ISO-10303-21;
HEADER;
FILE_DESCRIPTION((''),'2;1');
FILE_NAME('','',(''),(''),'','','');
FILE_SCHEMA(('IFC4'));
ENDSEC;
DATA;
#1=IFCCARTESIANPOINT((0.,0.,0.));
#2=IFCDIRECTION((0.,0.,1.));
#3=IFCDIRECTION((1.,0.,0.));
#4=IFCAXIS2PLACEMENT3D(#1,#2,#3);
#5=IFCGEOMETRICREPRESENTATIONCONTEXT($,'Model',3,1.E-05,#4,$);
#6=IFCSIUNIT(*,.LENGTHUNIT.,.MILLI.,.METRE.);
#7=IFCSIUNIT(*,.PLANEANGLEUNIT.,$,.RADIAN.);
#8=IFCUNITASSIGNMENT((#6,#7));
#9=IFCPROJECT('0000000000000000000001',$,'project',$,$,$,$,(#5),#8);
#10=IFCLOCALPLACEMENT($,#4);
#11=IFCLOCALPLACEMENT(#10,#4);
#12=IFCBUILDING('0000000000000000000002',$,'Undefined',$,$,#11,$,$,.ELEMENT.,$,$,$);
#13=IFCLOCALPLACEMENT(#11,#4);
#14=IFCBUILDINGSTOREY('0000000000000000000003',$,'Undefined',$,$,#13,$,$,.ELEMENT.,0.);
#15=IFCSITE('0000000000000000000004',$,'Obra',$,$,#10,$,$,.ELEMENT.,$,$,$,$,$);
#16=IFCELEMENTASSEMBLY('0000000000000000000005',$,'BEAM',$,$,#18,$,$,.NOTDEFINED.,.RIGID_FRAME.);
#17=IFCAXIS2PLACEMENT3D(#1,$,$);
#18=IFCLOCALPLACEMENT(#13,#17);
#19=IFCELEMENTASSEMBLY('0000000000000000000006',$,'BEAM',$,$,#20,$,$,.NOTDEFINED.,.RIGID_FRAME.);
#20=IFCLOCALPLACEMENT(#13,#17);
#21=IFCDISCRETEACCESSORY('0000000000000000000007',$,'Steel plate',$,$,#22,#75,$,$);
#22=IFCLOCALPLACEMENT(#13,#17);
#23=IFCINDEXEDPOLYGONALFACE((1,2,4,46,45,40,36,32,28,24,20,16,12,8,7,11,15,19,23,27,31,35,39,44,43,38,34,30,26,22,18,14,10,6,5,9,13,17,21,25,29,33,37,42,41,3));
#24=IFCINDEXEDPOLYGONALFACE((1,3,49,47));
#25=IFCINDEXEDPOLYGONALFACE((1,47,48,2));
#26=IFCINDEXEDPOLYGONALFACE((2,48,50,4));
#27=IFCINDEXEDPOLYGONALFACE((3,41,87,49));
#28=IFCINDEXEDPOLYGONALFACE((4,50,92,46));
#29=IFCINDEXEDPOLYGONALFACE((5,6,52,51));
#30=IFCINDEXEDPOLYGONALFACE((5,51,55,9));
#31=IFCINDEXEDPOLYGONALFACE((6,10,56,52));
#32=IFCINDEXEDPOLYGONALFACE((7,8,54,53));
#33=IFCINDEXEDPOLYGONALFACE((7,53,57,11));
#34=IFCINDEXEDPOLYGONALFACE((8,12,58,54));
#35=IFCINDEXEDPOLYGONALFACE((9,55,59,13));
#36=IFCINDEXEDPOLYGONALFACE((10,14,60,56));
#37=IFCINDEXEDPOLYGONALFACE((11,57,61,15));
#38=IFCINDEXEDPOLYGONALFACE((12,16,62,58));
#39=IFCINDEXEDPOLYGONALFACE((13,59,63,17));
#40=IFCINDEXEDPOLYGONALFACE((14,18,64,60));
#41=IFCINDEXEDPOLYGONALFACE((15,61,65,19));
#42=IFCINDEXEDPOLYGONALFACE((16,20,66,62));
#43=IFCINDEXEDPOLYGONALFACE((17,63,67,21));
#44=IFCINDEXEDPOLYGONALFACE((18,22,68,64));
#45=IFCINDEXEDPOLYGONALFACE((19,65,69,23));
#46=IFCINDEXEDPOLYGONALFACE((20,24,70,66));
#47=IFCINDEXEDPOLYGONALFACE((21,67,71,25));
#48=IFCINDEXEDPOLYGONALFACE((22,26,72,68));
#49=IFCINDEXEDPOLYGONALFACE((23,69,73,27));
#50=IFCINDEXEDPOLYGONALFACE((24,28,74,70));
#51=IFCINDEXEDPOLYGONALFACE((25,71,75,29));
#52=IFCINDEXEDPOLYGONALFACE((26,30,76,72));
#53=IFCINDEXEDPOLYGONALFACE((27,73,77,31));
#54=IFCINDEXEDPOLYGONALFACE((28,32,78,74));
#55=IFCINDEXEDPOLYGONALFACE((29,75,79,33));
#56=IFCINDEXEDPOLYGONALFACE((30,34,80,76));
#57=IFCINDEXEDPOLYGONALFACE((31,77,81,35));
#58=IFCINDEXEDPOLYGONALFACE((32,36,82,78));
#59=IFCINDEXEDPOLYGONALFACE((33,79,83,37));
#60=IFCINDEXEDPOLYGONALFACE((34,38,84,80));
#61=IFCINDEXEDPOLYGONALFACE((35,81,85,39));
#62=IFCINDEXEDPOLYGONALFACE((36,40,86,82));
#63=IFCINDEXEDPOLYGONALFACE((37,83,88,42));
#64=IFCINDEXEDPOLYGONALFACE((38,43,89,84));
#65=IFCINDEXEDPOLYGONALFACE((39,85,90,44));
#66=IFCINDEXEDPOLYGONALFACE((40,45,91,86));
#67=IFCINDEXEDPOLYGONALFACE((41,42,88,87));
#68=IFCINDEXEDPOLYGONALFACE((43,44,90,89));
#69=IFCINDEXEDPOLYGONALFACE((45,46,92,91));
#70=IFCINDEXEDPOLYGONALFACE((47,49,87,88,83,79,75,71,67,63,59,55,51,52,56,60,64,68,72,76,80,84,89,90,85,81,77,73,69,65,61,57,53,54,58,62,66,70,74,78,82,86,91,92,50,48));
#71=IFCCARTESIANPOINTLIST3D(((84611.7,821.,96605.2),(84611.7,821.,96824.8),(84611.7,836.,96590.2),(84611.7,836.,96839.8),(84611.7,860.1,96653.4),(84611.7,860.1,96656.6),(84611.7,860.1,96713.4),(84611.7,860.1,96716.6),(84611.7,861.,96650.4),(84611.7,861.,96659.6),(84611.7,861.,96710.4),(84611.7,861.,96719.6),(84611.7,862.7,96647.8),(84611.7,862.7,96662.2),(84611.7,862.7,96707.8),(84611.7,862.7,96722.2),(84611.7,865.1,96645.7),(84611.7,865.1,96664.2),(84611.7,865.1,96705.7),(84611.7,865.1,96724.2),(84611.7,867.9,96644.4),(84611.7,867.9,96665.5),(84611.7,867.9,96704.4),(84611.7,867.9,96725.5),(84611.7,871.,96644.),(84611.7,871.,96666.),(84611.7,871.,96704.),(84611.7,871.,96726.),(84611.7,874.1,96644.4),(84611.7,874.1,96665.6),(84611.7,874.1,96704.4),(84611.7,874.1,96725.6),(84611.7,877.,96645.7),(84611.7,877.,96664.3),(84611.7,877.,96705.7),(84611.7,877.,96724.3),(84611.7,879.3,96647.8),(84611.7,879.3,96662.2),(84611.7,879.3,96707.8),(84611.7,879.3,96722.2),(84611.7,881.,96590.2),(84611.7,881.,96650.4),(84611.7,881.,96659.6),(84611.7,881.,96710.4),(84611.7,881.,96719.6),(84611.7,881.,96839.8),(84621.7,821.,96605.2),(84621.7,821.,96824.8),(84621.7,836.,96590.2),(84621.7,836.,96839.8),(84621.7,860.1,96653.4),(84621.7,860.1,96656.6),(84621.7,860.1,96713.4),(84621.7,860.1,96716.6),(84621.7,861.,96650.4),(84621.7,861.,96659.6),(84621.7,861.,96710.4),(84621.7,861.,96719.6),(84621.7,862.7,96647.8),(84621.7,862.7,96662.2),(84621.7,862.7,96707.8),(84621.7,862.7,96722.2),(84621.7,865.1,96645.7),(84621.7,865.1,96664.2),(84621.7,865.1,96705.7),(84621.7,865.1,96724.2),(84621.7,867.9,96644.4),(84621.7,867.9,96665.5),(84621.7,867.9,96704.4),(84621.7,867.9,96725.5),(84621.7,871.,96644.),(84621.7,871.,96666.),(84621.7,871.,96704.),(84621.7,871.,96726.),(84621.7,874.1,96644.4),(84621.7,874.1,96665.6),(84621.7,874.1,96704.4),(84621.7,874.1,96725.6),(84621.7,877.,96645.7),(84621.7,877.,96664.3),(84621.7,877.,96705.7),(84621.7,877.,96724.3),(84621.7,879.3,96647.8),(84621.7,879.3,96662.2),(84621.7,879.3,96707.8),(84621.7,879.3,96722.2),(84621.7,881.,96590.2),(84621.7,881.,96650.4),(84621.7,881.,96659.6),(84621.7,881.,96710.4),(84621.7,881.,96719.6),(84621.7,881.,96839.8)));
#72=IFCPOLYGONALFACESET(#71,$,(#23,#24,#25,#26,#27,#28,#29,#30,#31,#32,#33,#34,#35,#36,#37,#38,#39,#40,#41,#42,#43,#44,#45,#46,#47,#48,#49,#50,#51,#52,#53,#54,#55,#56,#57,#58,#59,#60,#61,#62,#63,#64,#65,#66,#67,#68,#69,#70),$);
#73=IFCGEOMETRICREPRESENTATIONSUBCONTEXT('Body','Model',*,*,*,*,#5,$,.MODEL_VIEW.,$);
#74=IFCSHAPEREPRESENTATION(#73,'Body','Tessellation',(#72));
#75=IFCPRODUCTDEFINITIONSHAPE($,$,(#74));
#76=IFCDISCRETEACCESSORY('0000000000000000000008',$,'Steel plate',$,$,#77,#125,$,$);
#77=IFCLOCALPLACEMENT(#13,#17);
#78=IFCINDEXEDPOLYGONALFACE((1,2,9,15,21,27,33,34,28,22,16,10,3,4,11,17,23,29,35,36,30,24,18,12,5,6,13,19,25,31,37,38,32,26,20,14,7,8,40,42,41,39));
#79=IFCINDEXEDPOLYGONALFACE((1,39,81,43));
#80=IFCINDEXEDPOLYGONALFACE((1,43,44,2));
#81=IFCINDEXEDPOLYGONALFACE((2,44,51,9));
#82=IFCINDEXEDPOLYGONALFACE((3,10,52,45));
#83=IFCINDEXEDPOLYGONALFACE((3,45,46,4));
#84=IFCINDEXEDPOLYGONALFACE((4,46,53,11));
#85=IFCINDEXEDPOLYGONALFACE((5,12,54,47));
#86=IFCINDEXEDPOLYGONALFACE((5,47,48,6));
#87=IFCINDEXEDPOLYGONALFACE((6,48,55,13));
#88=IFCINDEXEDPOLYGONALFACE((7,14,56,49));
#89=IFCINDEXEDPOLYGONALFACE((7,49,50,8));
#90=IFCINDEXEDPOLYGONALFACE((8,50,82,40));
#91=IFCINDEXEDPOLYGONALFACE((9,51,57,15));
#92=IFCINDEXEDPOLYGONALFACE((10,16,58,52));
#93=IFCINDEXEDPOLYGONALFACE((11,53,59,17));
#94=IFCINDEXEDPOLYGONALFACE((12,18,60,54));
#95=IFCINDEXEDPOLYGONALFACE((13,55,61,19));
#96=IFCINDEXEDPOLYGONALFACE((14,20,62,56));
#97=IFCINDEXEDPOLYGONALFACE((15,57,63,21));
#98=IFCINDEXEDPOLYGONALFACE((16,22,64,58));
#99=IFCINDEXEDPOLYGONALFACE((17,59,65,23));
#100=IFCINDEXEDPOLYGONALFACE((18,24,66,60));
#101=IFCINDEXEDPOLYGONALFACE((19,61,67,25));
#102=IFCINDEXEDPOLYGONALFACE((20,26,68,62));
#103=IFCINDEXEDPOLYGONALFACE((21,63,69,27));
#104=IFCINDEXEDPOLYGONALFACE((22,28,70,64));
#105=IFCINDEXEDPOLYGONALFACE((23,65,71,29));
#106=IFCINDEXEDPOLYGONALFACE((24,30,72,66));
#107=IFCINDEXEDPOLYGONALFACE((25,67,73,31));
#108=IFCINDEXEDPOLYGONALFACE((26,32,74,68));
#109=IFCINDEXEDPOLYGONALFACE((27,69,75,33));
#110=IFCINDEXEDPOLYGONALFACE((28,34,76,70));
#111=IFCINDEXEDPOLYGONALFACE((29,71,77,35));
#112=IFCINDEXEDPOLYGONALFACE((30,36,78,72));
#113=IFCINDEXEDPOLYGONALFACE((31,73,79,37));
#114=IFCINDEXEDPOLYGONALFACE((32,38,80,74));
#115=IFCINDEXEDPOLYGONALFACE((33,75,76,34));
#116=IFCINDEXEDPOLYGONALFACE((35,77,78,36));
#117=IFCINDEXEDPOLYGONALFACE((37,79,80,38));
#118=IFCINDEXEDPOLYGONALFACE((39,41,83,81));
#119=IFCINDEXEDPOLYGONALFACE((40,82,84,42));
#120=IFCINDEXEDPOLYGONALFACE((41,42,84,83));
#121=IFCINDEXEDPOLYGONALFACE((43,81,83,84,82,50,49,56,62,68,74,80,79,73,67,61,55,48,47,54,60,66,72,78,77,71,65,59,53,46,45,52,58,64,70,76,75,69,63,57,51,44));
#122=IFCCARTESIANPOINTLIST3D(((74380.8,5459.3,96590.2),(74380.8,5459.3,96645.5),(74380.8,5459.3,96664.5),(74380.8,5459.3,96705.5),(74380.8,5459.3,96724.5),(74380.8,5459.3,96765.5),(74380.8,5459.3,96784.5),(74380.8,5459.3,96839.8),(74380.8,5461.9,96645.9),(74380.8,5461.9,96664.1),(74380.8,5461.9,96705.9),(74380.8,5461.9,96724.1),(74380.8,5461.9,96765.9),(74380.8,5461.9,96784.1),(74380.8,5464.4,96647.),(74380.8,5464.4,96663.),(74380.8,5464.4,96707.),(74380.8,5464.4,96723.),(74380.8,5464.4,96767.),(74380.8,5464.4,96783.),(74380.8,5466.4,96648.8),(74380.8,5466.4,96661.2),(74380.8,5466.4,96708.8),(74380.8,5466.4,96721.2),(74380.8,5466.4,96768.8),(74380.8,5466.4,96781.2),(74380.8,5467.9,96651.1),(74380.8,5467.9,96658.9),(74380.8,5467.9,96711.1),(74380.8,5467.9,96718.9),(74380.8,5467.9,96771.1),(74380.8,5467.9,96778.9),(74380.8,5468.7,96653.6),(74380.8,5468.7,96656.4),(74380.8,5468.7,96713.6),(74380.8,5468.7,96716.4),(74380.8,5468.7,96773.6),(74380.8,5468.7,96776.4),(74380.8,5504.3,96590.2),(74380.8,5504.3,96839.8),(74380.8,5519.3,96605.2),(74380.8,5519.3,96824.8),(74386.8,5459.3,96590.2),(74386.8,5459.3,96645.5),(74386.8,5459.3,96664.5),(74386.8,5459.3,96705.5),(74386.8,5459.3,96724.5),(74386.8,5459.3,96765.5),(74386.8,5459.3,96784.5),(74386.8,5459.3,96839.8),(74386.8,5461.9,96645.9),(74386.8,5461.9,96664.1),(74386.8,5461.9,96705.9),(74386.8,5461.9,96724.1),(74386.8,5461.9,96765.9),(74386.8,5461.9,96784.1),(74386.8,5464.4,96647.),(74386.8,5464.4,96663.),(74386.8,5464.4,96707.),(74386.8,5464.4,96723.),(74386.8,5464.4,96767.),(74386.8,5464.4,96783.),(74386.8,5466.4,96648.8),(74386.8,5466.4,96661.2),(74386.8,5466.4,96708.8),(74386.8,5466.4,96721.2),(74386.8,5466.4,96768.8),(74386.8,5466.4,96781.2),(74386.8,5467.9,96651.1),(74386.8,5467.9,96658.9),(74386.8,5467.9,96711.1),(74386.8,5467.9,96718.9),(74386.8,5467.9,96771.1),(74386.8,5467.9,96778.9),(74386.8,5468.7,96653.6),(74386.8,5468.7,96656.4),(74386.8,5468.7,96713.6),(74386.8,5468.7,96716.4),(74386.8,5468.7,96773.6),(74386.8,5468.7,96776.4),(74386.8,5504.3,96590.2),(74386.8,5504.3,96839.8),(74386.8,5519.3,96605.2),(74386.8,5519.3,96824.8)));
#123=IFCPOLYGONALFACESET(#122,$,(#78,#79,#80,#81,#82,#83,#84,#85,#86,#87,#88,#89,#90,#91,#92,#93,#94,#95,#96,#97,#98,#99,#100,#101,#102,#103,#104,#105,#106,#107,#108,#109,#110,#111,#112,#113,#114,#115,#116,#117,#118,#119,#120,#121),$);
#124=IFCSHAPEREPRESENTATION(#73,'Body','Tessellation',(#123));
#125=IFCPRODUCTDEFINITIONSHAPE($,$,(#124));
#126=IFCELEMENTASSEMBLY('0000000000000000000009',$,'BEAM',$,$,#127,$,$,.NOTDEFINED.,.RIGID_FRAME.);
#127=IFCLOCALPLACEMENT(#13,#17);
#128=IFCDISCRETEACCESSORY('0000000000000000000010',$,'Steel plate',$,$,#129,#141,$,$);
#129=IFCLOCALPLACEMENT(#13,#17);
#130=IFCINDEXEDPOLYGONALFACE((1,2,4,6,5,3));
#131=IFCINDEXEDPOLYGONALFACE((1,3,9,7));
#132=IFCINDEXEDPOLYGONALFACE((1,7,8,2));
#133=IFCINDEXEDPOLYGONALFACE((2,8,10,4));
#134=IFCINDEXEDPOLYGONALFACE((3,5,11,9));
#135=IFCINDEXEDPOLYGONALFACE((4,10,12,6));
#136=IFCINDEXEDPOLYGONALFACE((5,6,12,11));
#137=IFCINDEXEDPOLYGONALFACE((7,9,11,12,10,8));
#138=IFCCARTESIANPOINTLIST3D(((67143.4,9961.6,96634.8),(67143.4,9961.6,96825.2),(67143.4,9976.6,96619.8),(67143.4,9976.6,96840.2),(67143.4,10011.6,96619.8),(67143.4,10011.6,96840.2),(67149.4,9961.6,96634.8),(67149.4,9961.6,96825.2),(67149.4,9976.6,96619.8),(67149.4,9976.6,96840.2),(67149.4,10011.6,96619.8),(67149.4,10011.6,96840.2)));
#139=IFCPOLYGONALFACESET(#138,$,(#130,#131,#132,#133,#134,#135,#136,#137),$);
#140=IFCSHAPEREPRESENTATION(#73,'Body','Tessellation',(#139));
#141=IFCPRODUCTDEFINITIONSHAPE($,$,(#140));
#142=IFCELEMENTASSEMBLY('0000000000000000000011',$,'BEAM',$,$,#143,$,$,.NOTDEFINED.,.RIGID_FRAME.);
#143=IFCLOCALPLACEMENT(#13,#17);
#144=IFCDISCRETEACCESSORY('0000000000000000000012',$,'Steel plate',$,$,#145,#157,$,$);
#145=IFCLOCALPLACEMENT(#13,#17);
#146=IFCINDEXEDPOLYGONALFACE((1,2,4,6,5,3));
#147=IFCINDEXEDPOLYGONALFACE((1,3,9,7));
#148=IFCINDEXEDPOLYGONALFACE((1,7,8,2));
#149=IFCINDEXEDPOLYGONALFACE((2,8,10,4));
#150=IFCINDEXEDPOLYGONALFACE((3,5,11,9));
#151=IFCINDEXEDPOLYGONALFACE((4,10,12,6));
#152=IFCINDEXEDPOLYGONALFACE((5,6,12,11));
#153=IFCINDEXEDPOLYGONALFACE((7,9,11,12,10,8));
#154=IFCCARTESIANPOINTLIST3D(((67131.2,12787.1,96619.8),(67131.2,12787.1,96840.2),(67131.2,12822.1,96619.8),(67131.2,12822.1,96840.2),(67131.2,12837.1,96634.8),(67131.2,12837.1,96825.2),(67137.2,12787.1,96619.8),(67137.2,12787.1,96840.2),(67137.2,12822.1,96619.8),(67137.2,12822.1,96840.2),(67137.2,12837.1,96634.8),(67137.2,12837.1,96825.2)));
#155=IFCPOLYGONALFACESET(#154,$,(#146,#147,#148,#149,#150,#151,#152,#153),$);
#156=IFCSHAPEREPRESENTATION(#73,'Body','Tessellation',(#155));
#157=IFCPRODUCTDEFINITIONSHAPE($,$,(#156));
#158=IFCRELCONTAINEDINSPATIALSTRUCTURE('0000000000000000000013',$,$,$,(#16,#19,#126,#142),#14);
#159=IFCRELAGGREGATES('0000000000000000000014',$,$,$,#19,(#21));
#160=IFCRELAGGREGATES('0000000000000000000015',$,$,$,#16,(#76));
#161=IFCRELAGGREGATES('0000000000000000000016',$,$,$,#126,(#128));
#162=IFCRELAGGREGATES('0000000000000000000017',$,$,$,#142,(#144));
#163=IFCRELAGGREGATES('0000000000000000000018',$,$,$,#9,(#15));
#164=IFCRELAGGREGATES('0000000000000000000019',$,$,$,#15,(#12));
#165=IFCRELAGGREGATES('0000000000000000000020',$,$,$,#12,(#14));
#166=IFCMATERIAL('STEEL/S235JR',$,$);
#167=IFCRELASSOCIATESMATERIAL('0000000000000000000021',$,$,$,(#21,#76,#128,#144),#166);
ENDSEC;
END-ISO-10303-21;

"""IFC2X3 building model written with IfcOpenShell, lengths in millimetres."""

from ifc_helpers import new_model, si_unit, frame, origin_with_axes, origin_2d_with_axis, place, context, subcontext, project, spatial, polyline, circle, outline, extrude, source, transform, mapped, material, element, aggregate, save


model = new_model("IFC2X3")

# Units and contexts
model_context = context("Model", 3, precision=1e-05, world=origin_with_axes())
body_context = subcontext(model_context, "Body", "Model", "MODEL_VIEW")
ifc_project = project(units=[si_unit("LENGTHUNIT", "METRE", prefix="MILLI"), si_unit("PLANEANGLEUNIT", "RADIAN")], contexts=[model_context])

# Site, building, storey
site_placement = place(None, origin_with_axes())
site = spatial("IfcSite", under=ifc_project, at=site_placement, Name="Obra", CompositionType="ELEMENT")
building_placement = place(site_placement, origin_with_axes())
building = spatial("IfcBuilding", under=site, at=building_placement, Name="Undefined", CompositionType="ELEMENT")
storey_placement = place(building_placement, origin_with_axes())
storey = spatial("IfcBuildingStorey", under=building, at=storey_placement, Name="Undefined", CompositionType="ELEMENT", Elevation=0.0)

# Shared definitions
ifc_material = material(Name="STEEL/S235JR")

# Element assembly
assembly_1_placement = place(storey_placement, origin_with_axes())
assembly_1 = element("IfcElementAssembly", 1, at=assembly_1_placement, inside=storey, Name="BEAM", AssemblyPlace="NOTDEFINED", PredefinedType="RIGID_FRAME")
shared_shape_1 = source(origin_with_axes(), body_context, "Body", "SweptSolid", [
    extrude(circle(Radius=9.5, at=origin_2d_with_axis()), frame((0.0, -9.4, 0.0), z_axis=(0.0, 1.0, 0.0), x_axis=(1.0, 0.0, 0.0)), (0.0, 0.0, 1.0), 6.2),
])

# Element assembly, discrete accessory, opening
assembly_2_placement = place(storey_placement, origin_with_axes())
assembly_2 = element("IfcElementAssembly", 2, at=assembly_2_placement, inside=storey, Name="BEAM", AssemblyPlace="NOTDEFINED", PredefinedType="RIGID_FRAME")
discrete_accessory_1_placement = place(assembly_2_placement, frame((84616.7, 881.0, 96590.2), z_axis=(-1.0, 0.0, 0.0), x_axis=(0.0, -1.0, 0.0)))
discrete_accessory_1 = element("IfcDiscreteAccessory", 3, at=discrete_accessory_1_placement, material=ifc_material, Name="Steel plate", context=body_context, shape_type="SweptSolid", body=[
    extrude(outline(polyline([(0.0, 0.0), (45.0, 0.0), (60.0, 15.0), (60.0, 234.6), (45.0, 249.6), (0.0, 249.6), (0.0, 0.0)])), frame((0.0, 0.0, -5.0), z_axis=(0.0, 0.0, 1.0), x_axis=(1.0, 0.0, 0.0)), (0.0, 0.0, 1.0), 10.0),
])
shared_shape_2 = source(origin_with_axes(), body_context, "Body", "SweptSolid", [
    extrude(circle(Radius=11.0, at=origin_2d_with_axis()), frame((0.0, -13.9, 0.0), z_axis=(0.0, 1.0, 0.0), x_axis=(1.0, 0.0, 0.0)), (0.0, 0.0, 1.0), 10.2),
])
opening_1_placement = place(assembly_2_placement, frame((84607.9, 831.0, 96850.0), z_axis=(0.0, 1.0, 0.0), x_axis=(0.0, 0.0, -1.0)))
element("IfcOpeningElement", 4, at=opening_1_placement, cuts=discrete_accessory_1, ObjectType="Opening", context=body_context, shape_type="MappedRepresentation", body=[
    mapped(shared_shape_2, transform((135.0, 0.0, 40.0))),
    mapped(shared_shape_2, transform((195.0, 0.0, 40.0))),
])
aggregate(assembly_2, [discrete_accessory_1])

# Discrete accessory, opening
discrete_accessory_2_placement = place(assembly_1_placement, frame((74383.8, 5459.3, 96590.2), z_axis=(1.0, 0.0, 0.0), x_axis=(0.0, 1.0, 0.0)))
discrete_accessory_2 = element("IfcDiscreteAccessory", 5, at=discrete_accessory_2_placement, material=ifc_material, Name="Steel plate", context=body_context, shape_type="SweptSolid", body=[
    extrude(outline(polyline([(0.0, 0.0), (45.0, 0.0), (60.0, 15.0), (60.0, 234.6), (45.0, 249.6), (0.0, 249.6), (0.0, 0.0)])), frame((0.0, 0.0, -3.0), z_axis=(0.0, 0.0, 1.0), x_axis=(1.0, 0.0, 0.0)), (0.0, 0.0, 1.0), 6.0),
])
opening_2_placement = place(assembly_1_placement, frame((74390.1, 5509.3, 96850.0), z_axis=(0.0, -1.0, 0.0), x_axis=(0.0, 0.0, -1.0)))
element("IfcOpeningElement", 6, at=opening_2_placement, cuts=discrete_accessory_2, ObjectType="Opening", context=body_context, shape_type="MappedRepresentation", body=[
    mapped(shared_shape_1, transform((75.0, 0.0, 50.0))),
    mapped(shared_shape_1, transform((135.0, 0.0, 50.0))),
    mapped(shared_shape_1, transform((195.0, 0.0, 50.0))),
])
aggregate(assembly_1, [discrete_accessory_2])

# Element assemblies, discrete accessories
assembly_3_placement = place(storey_placement, origin_with_axes())
assembly_3 = element("IfcElementAssembly", 7, at=assembly_3_placement, inside=storey, Name="BEAM", AssemblyPlace="NOTDEFINED", PredefinedType="RIGID_FRAME")
discrete_accessory_3_placement = place(assembly_3_placement, frame((67146.4, 10011.6, 96619.8), z_axis=(-1.0, 0.0, 0.0), x_axis=(0.0, -1.0, 0.0)))
discrete_accessory_3 = element("IfcDiscreteAccessory", 8, at=discrete_accessory_3_placement, material=ifc_material, Name="Steel plate", context=body_context, shape_type="SweptSolid", body=[
    extrude(outline(polyline([(0.0, 0.0), (35.0, 0.0), (50.0, 15.0), (50.0, 205.4), (35.0, 220.4), (0.0, 220.4), (0.0, 0.0)])), frame((0.0, 0.0, -3.0), z_axis=(0.0, 0.0, 1.0), x_axis=(1.0, 0.0, 0.0)), (0.0, 0.0, 1.0), 6.0),
])
aggregate(assembly_3, [discrete_accessory_3])
assembly_4_placement = place(storey_placement, origin_with_axes())
assembly_4 = element("IfcElementAssembly", 9, at=assembly_4_placement, inside=storey, Name="BEAM", AssemblyPlace="NOTDEFINED", PredefinedType="RIGID_FRAME")
discrete_accessory_4_placement = place(assembly_4_placement, frame((67134.2, 12787.1, 96619.8), z_axis=(1.0, 0.0, 0.0), x_axis=(0.0, 1.0, 0.0)))
discrete_accessory_4 = element("IfcDiscreteAccessory", 10, at=discrete_accessory_4_placement, material=ifc_material, Name="Steel plate", context=body_context, shape_type="SweptSolid", body=[
    extrude(outline(polyline([(0.0, 0.0), (35.0, 0.0), (50.0, 15.0), (50.0, 205.4), (35.0, 220.4), (0.0, 220.4), (0.0, 0.0)])), frame((0.0, 0.0, -3.0), z_axis=(0.0, 0.0, 1.0), x_axis=(1.0, 0.0, 0.0)), (0.0, 0.0, 1.0), 6.0),
])
aggregate(assembly_4, [discrete_accessory_4])

save(model, "model.ifc")
